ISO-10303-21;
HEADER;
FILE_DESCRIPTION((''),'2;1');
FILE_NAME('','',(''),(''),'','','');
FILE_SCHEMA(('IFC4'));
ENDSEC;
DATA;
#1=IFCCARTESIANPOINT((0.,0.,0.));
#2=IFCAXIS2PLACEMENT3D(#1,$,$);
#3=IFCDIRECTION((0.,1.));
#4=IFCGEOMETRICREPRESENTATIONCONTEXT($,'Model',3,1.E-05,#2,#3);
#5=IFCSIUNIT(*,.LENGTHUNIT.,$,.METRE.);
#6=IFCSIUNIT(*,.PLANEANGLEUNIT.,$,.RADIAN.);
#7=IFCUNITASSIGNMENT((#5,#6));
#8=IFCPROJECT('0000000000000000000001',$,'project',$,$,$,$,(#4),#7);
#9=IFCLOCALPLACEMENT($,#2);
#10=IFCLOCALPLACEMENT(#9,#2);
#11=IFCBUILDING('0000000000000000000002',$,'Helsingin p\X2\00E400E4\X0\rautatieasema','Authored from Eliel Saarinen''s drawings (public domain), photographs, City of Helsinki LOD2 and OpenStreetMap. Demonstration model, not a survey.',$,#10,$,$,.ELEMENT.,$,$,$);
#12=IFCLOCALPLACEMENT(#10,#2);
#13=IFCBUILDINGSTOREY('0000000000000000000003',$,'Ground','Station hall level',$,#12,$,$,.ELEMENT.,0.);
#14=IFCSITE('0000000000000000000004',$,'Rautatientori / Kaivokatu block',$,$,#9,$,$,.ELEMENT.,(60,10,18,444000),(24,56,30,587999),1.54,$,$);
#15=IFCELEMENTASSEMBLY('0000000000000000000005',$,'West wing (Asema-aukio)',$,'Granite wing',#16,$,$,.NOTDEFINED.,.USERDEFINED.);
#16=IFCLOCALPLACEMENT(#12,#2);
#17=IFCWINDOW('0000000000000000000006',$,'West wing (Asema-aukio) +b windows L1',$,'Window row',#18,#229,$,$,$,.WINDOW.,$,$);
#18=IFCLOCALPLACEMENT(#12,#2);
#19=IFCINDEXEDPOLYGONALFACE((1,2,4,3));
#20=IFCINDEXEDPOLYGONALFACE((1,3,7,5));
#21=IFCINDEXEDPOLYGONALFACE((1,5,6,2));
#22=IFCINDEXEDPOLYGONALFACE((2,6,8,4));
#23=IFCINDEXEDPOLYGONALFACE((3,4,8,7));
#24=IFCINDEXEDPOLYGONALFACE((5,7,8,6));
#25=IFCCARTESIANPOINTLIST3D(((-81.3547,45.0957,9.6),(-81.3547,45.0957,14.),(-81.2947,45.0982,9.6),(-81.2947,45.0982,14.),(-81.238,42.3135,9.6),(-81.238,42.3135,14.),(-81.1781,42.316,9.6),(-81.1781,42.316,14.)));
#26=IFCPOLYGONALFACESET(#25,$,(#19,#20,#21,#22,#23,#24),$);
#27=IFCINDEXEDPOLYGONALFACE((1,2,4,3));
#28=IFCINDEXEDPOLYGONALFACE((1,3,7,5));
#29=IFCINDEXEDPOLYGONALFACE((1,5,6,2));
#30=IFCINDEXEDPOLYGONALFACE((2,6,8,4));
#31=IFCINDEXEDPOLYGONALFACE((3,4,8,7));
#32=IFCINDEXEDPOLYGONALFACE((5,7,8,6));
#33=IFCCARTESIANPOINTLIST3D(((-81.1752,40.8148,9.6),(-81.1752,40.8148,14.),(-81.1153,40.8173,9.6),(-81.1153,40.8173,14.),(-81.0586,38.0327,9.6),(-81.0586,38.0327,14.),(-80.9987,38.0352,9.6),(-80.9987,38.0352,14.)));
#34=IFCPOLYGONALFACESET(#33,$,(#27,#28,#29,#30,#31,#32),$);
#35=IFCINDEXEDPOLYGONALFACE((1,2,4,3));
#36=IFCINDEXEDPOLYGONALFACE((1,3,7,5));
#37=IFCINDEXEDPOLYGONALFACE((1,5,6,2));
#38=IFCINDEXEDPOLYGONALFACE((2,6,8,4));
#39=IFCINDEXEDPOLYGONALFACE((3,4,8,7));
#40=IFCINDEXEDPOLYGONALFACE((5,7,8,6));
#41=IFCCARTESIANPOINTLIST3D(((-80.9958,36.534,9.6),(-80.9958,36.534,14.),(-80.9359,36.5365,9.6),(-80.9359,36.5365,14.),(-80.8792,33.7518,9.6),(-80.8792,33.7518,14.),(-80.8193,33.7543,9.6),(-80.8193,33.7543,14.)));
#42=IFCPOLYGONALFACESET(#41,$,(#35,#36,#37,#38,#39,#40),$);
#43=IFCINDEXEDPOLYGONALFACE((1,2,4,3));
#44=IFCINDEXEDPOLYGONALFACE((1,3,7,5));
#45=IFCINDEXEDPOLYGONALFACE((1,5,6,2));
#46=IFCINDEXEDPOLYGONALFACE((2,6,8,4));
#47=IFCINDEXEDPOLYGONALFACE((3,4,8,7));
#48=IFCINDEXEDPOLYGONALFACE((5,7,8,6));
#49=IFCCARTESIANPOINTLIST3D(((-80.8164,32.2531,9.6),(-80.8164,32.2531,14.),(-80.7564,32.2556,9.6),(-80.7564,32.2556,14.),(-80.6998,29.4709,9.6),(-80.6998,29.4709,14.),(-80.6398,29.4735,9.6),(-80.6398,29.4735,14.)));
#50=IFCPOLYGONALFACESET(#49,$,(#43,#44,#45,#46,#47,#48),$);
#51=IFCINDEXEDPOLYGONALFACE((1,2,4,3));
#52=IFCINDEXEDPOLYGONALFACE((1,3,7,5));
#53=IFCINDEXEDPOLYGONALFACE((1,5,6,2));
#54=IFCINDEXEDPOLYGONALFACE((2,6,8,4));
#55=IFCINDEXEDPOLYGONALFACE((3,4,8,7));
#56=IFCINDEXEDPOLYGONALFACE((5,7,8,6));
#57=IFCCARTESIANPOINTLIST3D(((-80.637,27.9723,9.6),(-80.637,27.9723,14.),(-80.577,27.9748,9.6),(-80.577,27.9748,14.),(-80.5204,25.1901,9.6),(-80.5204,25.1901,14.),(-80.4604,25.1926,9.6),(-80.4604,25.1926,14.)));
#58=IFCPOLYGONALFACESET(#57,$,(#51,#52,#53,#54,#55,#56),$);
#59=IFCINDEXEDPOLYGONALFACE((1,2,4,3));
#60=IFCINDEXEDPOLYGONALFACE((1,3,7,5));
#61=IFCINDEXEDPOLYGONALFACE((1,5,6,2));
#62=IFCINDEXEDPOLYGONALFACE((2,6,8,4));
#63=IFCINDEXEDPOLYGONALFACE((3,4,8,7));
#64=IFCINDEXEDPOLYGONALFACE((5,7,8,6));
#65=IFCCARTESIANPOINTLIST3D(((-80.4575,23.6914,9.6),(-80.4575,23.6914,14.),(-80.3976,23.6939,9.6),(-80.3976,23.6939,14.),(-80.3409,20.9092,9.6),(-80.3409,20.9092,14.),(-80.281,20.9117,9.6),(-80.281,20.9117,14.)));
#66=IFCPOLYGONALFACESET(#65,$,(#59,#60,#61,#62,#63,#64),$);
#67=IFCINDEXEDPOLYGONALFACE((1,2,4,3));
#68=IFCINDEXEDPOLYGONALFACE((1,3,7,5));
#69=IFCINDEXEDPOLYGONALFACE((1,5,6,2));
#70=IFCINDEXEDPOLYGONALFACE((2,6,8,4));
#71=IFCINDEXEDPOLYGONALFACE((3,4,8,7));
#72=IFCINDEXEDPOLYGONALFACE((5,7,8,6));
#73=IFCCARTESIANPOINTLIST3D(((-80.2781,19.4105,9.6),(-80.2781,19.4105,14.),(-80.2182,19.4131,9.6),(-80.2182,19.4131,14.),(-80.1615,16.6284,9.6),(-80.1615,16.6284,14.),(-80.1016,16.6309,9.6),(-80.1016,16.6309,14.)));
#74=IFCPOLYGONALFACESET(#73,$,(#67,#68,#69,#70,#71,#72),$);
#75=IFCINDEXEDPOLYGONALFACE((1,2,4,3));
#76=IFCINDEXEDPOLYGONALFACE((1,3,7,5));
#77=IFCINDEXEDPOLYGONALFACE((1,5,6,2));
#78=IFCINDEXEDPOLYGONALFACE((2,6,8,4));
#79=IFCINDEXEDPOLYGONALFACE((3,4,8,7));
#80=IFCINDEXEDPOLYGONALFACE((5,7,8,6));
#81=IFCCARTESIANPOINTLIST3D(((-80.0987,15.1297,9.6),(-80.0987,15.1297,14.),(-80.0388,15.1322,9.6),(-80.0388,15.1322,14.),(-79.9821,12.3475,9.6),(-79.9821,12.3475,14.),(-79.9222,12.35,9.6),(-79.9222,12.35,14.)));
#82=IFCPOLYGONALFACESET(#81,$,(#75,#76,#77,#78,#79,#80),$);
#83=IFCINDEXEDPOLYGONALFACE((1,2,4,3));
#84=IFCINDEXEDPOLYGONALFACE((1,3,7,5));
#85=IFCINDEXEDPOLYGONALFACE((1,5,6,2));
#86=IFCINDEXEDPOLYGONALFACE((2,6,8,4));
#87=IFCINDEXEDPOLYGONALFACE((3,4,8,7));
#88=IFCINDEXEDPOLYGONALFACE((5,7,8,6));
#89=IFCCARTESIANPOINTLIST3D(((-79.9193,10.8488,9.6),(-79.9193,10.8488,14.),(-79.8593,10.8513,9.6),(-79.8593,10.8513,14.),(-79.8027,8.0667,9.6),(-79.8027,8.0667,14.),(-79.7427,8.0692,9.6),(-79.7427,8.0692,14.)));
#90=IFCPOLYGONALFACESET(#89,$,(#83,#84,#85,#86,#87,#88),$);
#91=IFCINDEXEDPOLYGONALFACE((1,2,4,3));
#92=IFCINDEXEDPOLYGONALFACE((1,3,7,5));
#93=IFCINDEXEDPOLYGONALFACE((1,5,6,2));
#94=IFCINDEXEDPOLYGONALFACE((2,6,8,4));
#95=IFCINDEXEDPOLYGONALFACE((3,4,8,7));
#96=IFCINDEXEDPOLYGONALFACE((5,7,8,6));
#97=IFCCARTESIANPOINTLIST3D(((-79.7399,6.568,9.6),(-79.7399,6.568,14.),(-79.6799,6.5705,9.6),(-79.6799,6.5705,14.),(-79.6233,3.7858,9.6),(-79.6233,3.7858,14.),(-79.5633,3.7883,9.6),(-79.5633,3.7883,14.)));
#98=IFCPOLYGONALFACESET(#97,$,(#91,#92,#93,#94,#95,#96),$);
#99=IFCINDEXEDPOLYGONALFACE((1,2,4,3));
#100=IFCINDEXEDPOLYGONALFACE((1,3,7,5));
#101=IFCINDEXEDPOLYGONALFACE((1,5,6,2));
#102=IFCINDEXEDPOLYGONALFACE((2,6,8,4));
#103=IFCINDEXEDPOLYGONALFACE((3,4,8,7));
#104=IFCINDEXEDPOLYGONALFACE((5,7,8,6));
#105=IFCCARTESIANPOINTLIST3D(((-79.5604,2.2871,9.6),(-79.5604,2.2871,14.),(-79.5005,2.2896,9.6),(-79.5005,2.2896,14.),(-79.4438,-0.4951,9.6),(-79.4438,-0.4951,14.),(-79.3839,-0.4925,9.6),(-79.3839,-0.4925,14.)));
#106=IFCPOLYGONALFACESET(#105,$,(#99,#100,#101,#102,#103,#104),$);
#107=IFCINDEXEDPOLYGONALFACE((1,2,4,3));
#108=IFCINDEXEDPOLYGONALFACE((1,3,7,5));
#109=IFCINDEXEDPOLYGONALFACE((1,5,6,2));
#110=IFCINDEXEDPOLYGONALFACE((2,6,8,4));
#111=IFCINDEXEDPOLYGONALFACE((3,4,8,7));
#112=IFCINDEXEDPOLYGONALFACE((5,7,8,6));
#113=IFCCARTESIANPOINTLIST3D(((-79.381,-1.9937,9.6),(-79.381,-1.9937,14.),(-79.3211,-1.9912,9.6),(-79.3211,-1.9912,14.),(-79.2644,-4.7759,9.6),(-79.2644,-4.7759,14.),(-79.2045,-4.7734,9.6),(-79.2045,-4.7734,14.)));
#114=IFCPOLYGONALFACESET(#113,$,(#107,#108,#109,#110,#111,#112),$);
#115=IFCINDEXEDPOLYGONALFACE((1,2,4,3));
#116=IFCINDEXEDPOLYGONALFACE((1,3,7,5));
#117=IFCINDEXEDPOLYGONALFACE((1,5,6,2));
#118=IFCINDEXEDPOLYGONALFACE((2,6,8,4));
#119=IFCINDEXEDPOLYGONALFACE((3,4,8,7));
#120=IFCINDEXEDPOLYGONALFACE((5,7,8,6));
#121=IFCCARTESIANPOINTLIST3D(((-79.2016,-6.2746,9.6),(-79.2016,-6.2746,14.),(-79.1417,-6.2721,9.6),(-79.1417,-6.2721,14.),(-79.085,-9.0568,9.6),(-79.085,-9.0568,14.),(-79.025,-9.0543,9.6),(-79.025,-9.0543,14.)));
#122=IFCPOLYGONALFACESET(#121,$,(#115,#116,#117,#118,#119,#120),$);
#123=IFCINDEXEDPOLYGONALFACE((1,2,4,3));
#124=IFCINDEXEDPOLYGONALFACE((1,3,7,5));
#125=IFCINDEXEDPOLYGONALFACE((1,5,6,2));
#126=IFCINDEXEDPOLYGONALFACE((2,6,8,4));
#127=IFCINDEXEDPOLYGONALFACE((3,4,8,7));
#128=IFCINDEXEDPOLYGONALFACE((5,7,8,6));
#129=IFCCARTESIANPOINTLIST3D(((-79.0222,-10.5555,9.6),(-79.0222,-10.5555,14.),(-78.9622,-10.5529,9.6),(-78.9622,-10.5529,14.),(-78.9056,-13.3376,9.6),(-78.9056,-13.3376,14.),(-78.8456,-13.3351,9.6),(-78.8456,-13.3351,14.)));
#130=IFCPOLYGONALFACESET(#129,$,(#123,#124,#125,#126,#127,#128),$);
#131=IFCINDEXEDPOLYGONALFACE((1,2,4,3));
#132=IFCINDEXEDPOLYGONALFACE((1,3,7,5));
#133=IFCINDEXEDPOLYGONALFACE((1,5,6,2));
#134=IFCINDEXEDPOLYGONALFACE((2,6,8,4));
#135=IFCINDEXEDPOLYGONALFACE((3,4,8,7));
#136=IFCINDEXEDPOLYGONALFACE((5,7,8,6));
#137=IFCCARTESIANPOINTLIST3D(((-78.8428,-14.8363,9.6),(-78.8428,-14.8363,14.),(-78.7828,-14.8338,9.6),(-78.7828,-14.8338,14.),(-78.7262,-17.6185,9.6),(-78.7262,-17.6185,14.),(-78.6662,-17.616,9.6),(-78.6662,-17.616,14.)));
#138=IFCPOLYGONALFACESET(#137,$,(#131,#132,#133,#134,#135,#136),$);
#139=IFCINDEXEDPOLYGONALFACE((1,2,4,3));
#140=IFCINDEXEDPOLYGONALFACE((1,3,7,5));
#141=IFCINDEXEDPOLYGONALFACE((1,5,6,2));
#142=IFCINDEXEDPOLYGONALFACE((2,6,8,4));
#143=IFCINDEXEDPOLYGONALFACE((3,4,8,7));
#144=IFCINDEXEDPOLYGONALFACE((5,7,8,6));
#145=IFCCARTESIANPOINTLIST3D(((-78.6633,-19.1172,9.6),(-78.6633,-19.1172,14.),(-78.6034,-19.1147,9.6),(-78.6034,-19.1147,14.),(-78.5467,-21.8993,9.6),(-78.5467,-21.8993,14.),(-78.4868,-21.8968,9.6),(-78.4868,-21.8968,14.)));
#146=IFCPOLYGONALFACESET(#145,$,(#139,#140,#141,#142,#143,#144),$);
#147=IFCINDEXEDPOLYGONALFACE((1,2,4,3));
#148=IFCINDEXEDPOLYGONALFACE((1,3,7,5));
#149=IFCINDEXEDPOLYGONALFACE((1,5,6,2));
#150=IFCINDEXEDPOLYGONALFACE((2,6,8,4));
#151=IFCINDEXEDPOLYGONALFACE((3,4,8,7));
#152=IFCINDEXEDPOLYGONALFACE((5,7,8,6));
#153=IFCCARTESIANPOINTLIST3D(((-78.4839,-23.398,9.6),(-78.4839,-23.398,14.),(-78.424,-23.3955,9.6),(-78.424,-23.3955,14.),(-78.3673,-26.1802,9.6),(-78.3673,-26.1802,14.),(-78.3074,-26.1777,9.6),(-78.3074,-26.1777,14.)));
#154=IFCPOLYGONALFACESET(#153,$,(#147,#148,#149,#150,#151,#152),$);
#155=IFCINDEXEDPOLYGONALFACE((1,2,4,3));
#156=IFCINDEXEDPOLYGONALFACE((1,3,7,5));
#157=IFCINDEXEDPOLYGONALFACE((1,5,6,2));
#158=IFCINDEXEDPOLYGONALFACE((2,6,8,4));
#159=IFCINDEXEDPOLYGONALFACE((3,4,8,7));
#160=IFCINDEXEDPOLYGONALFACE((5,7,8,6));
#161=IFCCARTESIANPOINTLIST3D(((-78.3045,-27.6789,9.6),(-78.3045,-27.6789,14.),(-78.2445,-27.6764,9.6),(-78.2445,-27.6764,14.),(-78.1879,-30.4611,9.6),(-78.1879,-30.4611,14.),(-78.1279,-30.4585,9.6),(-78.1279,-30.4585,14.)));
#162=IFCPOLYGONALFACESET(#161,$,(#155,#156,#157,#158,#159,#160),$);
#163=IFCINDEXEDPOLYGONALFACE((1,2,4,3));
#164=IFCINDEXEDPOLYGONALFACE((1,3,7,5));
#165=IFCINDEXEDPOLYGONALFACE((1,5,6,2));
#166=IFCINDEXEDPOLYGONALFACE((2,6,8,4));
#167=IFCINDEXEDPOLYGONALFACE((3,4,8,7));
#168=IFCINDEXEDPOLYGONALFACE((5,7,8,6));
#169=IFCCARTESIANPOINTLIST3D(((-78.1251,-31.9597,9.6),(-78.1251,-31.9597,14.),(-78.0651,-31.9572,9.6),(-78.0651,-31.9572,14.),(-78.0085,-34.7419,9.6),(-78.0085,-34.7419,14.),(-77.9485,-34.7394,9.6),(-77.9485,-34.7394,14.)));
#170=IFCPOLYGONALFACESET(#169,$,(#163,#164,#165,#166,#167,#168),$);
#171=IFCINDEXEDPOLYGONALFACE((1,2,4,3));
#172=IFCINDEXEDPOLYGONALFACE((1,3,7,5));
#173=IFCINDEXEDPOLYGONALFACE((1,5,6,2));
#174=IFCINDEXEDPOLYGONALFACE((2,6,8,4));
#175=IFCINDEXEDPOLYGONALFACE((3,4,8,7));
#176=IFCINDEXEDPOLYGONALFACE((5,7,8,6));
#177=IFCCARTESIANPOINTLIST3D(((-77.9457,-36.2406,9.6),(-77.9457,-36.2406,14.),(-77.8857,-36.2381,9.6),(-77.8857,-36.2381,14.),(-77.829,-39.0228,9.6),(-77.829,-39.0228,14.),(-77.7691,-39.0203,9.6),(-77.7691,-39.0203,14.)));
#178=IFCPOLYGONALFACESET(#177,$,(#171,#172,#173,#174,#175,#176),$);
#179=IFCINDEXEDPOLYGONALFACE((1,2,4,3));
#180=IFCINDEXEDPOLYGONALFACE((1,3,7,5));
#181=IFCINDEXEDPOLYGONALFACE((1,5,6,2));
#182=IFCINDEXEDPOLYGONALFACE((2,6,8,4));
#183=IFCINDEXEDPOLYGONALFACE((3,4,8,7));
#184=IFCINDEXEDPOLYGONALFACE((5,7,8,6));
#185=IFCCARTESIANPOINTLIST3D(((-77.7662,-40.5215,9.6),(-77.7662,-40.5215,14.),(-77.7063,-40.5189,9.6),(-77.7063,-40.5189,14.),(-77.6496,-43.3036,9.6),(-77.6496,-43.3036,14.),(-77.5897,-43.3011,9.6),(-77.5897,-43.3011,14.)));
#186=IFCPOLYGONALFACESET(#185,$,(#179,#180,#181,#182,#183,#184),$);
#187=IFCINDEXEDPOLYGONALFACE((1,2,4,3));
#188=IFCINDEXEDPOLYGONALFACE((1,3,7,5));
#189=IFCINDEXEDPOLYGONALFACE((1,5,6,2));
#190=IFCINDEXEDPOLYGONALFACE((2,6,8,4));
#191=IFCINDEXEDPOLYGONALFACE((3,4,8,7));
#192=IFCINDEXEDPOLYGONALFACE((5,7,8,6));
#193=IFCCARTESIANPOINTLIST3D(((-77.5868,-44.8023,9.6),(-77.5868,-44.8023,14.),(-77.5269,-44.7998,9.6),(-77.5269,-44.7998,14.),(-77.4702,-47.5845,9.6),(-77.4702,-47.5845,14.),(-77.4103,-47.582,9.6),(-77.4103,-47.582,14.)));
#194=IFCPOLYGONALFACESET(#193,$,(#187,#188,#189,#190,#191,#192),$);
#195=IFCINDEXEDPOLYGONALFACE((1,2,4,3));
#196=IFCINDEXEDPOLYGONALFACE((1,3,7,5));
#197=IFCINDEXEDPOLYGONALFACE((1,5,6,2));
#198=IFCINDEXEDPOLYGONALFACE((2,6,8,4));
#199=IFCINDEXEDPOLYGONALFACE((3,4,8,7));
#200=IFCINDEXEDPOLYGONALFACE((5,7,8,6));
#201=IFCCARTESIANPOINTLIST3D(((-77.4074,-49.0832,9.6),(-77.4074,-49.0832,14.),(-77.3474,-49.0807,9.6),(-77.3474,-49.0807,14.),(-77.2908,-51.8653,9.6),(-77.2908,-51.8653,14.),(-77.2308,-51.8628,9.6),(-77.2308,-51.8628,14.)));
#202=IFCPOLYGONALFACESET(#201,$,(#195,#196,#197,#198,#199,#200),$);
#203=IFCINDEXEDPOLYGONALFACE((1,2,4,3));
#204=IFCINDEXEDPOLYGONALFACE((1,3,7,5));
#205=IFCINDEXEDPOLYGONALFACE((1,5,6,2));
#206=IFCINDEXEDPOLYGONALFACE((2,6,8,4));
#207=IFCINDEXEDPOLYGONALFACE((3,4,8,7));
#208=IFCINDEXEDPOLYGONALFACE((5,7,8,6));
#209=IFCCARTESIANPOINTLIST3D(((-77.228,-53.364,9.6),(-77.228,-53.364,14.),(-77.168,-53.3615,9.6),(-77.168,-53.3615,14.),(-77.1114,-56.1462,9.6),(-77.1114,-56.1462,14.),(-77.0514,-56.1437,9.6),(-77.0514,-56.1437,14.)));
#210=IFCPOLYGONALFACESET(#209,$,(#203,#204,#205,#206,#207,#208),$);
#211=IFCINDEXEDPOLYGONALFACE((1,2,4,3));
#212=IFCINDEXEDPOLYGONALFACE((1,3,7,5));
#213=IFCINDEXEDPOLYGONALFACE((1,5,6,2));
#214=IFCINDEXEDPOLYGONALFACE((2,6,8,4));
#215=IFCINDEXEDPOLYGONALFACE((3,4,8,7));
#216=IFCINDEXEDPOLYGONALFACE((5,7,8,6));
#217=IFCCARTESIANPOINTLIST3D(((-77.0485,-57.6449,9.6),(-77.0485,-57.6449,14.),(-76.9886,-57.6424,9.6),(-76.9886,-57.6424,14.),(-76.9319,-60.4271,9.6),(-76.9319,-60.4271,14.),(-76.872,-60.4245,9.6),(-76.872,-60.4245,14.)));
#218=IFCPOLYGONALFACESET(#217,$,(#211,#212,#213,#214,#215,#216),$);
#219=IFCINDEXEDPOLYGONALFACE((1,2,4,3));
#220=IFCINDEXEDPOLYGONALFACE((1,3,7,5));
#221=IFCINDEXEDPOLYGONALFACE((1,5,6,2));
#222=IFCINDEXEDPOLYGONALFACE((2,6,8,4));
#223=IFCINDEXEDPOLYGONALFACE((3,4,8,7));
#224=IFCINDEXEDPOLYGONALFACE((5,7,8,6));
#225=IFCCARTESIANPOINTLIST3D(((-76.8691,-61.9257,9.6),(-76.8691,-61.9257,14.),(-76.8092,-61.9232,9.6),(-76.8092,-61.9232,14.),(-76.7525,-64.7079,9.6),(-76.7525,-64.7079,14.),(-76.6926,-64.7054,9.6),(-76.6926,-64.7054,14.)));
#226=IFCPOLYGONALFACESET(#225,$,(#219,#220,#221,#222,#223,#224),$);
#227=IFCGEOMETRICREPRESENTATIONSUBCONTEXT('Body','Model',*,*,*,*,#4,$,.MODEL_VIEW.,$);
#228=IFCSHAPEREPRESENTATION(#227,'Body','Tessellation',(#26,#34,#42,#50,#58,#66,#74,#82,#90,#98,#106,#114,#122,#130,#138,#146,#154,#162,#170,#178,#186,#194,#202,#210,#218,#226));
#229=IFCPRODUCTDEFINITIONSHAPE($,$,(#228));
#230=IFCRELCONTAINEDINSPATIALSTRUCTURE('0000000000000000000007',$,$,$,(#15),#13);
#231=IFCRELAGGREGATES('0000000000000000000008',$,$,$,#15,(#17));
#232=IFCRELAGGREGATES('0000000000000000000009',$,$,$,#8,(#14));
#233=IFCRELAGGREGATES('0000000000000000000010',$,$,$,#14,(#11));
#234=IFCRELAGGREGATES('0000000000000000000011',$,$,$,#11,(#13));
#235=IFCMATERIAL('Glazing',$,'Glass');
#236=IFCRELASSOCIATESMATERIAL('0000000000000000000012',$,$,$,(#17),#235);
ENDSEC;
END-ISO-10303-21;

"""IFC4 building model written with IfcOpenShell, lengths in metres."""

from ifc_helpers import new_model, si_unit, direction, frame, frame_2d, origin, place, context, subcontext, project, spatial, rectangle, extrude, material, element, aggregate, save


model = new_model("IFC4")

# Units and contexts
model_context = context("Model", 3, precision=1e-05, world=origin(), true_north=direction((0.0, 1.0)))
body_context = subcontext(model_context, "Body", "Model", "MODEL_VIEW")
ifc_project = project(units=[si_unit("LENGTHUNIT", "METRE"), si_unit("PLANEANGLEUNIT", "RADIAN")], contexts=[model_context])

# Site, building, storey
site_placement = place(None, origin())
site = spatial("IfcSite", under=ifc_project, at=site_placement, Name="Rautatientori / Kaivokatu block", CompositionType="ELEMENT", RefLatitude=(60, 10, 18, 444000), RefLongitude=(24, 56, 30, 587999), RefElevation=1.54)
building_placement = place(site_placement, origin())
building = spatial("IfcBuilding", under=site, at=building_placement, Name="Helsingin päärautatieasema", Description="Authored from Eliel Saarinen's drawings (public domain), photographs, City of Helsinki LOD2 and OpenStreetMap. Demonstration model, not a survey.", CompositionType="ELEMENT")
storey_placement = place(building_placement, origin())
storey = spatial("IfcBuildingStorey", under=building, at=storey_placement, Name="Ground", Description="Station hall level", CompositionType="ELEMENT", Elevation=0.0)

# Element assembly, window
assembly_placement = place(building_placement, origin())
assembly = element("IfcElementAssembly", 1, at=assembly_placement, inside=storey, Name="West wing (Asema-aukio)", ObjectType="Granite wing", AssemblyPlace="NOTDEFINED", PredefinedType="USERDEFINED")
ifc_material_1 = material(Name="Glazing", Category="Glass")
window_1_placement = place(building_placement, origin())
window_1 = element("IfcWindow", 2, at=window_1_placement, material=ifc_material_1, Name="West wing (Asema-aukio) +b windows L1", ObjectType="Window row", PredefinedType="WINDOW", context=body_context, shape_type="SweptSolid", body=[
    extrude(rectangle(XDim=2.7846, YDim=0.06, at=frame_2d((0.0, 0.0), x_axis=(0.041876, -0.999123))), frame((-81.2664, 43.7059, 9.6)), (0.0, 0.0, 1.0), 4.4),
    extrude(rectangle(XDim=2.7846, YDim=0.06, at=frame_2d((0.0, 0.0), x_axis=(0.041876, -0.999123))), frame((-81.087, 39.425, 9.6)), (0.0, 0.0, 1.0), 4.4),
    extrude(rectangle(XDim=2.7846, YDim=0.06, at=frame_2d((0.0, 0.0), x_axis=(0.041876, -0.999123))), frame((-80.9075, 35.1441, 9.6)), (0.0, 0.0, 1.0), 4.4),
    extrude(rectangle(XDim=2.7846, YDim=0.06, at=frame_2d((0.0, 0.0), x_axis=(0.041876, -0.999123))), frame((-80.7281, 30.8633, 9.6)), (0.0, 0.0, 1.0), 4.4),
    extrude(rectangle(XDim=2.7846, YDim=0.06, at=frame_2d((0.0, 0.0), x_axis=(0.041876, -0.999123))), frame((-80.5487, 26.5824, 9.6)), (0.0, 0.0, 1.0), 4.4),
    extrude(rectangle(XDim=2.7846, YDim=0.06, at=frame_2d((0.0, 0.0), x_axis=(0.041876, -0.999123))), frame((-80.3693, 22.3016, 9.6)), (0.0, 0.0, 1.0), 4.4),
    extrude(rectangle(XDim=2.7846, YDim=0.06, at=frame_2d((0.0, 0.0), x_axis=(0.041876, -0.999123))), frame((-80.1899, 18.0207, 9.6)), (0.0, 0.0, 1.0), 4.4),
    extrude(rectangle(XDim=2.7846, YDim=0.06, at=frame_2d((0.0, 0.0), x_axis=(0.041876, -0.999123))), frame((-80.0104, 13.7399, 9.6)), (0.0, 0.0, 1.0), 4.4),
    extrude(rectangle(XDim=2.7846, YDim=0.06, at=frame_2d((0.0, 0.0), x_axis=(0.041876, -0.999123))), frame((-79.831, 9.459, 9.6)), (0.0, 0.0, 1.0), 4.4),
    extrude(rectangle(XDim=2.7846, YDim=0.06, at=frame_2d((0.0, 0.0), x_axis=(0.041876, -0.999123))), frame((-79.6516, 5.1781, 9.6)), (0.0, 0.0, 1.0), 4.4),
    extrude(rectangle(XDim=2.7846, YDim=0.06, at=frame_2d((0.0, 0.0), x_axis=(0.041876, -0.999123))), frame((-79.4722, 0.8973, 9.6)), (0.0, 0.0, 1.0), 4.4),
    extrude(rectangle(XDim=2.7846, YDim=0.06, at=frame_2d((0.0, 0.0), x_axis=(0.041876, -0.999123))), frame((-79.2927, -3.3836, 9.6)), (0.0, 0.0, 1.0), 4.4),
    extrude(rectangle(XDim=2.7846, YDim=0.06, at=frame_2d((0.0, 0.0), x_axis=(0.041876, -0.999123))), frame((-79.1133, -7.6644, 9.6)), (0.0, 0.0, 1.0), 4.4),
    extrude(rectangle(XDim=2.7846, YDim=0.06, at=frame_2d((0.0, 0.0), x_axis=(0.041876, -0.999123))), frame((-78.9339, -11.9453, 9.6)), (0.0, 0.0, 1.0), 4.4),
    extrude(rectangle(XDim=2.7846, YDim=0.06, at=frame_2d((0.0, 0.0), x_axis=(0.041876, -0.999123))), frame((-78.7545, -16.2261, 9.6)), (0.0, 0.0, 1.0), 4.4),
    extrude(rectangle(XDim=2.7846, YDim=0.06, at=frame_2d((0.0, 0.0), x_axis=(0.041876, -0.999123))), frame((-78.5751, -20.507, 9.6)), (0.0, 0.0, 1.0), 4.4),
    extrude(rectangle(XDim=2.7846, YDim=0.06, at=frame_2d((0.0, 0.0), x_axis=(0.041876, -0.999123))), frame((-78.3956, -24.7879, 9.6)), (0.0, 0.0, 1.0), 4.4),
    extrude(rectangle(XDim=2.7846, YDim=0.06, at=frame_2d((0.0, 0.0), x_axis=(0.041876, -0.999123))), frame((-78.2162, -29.0687, 9.6)), (0.0, 0.0, 1.0), 4.4),
    extrude(rectangle(XDim=2.7846, YDim=0.06, at=frame_2d((0.0, 0.0), x_axis=(0.041876, -0.999123))), frame((-78.0368, -33.3496, 9.6)), (0.0, 0.0, 1.0), 4.4),
    extrude(rectangle(XDim=2.7846, YDim=0.06, at=frame_2d((0.0, 0.0), x_axis=(0.041876, -0.999123))), frame((-77.8574, -37.6304, 9.6)), (0.0, 0.0, 1.0), 4.4),
    extrude(rectangle(XDim=2.7846, YDim=0.06, at=frame_2d((0.0, 0.0), x_axis=(0.041876, -0.999123))), frame((-77.678, -41.9113, 9.6)), (0.0, 0.0, 1.0), 4.4),
    extrude(rectangle(XDim=2.7846, YDim=0.06, at=frame_2d((0.0, 0.0), x_axis=(0.041876, -0.999123))), frame((-77.4985, -46.1921, 9.6)), (0.0, 0.0, 1.0), 4.4),
    extrude(rectangle(XDim=2.7846, YDim=0.06, at=frame_2d((0.0, 0.0), x_axis=(0.041876, -0.999123))), frame((-77.3191, -50.473, 9.6)), (0.0, 0.0, 1.0), 4.4),
    extrude(rectangle(XDim=2.7846, YDim=0.06, at=frame_2d((0.0, 0.0), x_axis=(0.041876, -0.999123))), frame((-77.1397, -54.7539, 9.6)), (0.0, 0.0, 1.0), 4.4),
    extrude(rectangle(XDim=2.7846, YDim=0.06, at=frame_2d((0.0, 0.0), x_axis=(0.041876, -0.999123))), frame((-76.9603, -59.0347, 9.6)), (0.0, 0.0, 1.0), 4.4),
    extrude(rectangle(XDim=2.7846, YDim=0.06, at=frame_2d((0.0, 0.0), x_axis=(0.041876, -0.999123))), frame((-76.7809, -63.3156, 9.6)), (0.0, 0.0, 1.0), 4.4),
])
aggregate(assembly, [window_1])

save(model, "model.ifc")
